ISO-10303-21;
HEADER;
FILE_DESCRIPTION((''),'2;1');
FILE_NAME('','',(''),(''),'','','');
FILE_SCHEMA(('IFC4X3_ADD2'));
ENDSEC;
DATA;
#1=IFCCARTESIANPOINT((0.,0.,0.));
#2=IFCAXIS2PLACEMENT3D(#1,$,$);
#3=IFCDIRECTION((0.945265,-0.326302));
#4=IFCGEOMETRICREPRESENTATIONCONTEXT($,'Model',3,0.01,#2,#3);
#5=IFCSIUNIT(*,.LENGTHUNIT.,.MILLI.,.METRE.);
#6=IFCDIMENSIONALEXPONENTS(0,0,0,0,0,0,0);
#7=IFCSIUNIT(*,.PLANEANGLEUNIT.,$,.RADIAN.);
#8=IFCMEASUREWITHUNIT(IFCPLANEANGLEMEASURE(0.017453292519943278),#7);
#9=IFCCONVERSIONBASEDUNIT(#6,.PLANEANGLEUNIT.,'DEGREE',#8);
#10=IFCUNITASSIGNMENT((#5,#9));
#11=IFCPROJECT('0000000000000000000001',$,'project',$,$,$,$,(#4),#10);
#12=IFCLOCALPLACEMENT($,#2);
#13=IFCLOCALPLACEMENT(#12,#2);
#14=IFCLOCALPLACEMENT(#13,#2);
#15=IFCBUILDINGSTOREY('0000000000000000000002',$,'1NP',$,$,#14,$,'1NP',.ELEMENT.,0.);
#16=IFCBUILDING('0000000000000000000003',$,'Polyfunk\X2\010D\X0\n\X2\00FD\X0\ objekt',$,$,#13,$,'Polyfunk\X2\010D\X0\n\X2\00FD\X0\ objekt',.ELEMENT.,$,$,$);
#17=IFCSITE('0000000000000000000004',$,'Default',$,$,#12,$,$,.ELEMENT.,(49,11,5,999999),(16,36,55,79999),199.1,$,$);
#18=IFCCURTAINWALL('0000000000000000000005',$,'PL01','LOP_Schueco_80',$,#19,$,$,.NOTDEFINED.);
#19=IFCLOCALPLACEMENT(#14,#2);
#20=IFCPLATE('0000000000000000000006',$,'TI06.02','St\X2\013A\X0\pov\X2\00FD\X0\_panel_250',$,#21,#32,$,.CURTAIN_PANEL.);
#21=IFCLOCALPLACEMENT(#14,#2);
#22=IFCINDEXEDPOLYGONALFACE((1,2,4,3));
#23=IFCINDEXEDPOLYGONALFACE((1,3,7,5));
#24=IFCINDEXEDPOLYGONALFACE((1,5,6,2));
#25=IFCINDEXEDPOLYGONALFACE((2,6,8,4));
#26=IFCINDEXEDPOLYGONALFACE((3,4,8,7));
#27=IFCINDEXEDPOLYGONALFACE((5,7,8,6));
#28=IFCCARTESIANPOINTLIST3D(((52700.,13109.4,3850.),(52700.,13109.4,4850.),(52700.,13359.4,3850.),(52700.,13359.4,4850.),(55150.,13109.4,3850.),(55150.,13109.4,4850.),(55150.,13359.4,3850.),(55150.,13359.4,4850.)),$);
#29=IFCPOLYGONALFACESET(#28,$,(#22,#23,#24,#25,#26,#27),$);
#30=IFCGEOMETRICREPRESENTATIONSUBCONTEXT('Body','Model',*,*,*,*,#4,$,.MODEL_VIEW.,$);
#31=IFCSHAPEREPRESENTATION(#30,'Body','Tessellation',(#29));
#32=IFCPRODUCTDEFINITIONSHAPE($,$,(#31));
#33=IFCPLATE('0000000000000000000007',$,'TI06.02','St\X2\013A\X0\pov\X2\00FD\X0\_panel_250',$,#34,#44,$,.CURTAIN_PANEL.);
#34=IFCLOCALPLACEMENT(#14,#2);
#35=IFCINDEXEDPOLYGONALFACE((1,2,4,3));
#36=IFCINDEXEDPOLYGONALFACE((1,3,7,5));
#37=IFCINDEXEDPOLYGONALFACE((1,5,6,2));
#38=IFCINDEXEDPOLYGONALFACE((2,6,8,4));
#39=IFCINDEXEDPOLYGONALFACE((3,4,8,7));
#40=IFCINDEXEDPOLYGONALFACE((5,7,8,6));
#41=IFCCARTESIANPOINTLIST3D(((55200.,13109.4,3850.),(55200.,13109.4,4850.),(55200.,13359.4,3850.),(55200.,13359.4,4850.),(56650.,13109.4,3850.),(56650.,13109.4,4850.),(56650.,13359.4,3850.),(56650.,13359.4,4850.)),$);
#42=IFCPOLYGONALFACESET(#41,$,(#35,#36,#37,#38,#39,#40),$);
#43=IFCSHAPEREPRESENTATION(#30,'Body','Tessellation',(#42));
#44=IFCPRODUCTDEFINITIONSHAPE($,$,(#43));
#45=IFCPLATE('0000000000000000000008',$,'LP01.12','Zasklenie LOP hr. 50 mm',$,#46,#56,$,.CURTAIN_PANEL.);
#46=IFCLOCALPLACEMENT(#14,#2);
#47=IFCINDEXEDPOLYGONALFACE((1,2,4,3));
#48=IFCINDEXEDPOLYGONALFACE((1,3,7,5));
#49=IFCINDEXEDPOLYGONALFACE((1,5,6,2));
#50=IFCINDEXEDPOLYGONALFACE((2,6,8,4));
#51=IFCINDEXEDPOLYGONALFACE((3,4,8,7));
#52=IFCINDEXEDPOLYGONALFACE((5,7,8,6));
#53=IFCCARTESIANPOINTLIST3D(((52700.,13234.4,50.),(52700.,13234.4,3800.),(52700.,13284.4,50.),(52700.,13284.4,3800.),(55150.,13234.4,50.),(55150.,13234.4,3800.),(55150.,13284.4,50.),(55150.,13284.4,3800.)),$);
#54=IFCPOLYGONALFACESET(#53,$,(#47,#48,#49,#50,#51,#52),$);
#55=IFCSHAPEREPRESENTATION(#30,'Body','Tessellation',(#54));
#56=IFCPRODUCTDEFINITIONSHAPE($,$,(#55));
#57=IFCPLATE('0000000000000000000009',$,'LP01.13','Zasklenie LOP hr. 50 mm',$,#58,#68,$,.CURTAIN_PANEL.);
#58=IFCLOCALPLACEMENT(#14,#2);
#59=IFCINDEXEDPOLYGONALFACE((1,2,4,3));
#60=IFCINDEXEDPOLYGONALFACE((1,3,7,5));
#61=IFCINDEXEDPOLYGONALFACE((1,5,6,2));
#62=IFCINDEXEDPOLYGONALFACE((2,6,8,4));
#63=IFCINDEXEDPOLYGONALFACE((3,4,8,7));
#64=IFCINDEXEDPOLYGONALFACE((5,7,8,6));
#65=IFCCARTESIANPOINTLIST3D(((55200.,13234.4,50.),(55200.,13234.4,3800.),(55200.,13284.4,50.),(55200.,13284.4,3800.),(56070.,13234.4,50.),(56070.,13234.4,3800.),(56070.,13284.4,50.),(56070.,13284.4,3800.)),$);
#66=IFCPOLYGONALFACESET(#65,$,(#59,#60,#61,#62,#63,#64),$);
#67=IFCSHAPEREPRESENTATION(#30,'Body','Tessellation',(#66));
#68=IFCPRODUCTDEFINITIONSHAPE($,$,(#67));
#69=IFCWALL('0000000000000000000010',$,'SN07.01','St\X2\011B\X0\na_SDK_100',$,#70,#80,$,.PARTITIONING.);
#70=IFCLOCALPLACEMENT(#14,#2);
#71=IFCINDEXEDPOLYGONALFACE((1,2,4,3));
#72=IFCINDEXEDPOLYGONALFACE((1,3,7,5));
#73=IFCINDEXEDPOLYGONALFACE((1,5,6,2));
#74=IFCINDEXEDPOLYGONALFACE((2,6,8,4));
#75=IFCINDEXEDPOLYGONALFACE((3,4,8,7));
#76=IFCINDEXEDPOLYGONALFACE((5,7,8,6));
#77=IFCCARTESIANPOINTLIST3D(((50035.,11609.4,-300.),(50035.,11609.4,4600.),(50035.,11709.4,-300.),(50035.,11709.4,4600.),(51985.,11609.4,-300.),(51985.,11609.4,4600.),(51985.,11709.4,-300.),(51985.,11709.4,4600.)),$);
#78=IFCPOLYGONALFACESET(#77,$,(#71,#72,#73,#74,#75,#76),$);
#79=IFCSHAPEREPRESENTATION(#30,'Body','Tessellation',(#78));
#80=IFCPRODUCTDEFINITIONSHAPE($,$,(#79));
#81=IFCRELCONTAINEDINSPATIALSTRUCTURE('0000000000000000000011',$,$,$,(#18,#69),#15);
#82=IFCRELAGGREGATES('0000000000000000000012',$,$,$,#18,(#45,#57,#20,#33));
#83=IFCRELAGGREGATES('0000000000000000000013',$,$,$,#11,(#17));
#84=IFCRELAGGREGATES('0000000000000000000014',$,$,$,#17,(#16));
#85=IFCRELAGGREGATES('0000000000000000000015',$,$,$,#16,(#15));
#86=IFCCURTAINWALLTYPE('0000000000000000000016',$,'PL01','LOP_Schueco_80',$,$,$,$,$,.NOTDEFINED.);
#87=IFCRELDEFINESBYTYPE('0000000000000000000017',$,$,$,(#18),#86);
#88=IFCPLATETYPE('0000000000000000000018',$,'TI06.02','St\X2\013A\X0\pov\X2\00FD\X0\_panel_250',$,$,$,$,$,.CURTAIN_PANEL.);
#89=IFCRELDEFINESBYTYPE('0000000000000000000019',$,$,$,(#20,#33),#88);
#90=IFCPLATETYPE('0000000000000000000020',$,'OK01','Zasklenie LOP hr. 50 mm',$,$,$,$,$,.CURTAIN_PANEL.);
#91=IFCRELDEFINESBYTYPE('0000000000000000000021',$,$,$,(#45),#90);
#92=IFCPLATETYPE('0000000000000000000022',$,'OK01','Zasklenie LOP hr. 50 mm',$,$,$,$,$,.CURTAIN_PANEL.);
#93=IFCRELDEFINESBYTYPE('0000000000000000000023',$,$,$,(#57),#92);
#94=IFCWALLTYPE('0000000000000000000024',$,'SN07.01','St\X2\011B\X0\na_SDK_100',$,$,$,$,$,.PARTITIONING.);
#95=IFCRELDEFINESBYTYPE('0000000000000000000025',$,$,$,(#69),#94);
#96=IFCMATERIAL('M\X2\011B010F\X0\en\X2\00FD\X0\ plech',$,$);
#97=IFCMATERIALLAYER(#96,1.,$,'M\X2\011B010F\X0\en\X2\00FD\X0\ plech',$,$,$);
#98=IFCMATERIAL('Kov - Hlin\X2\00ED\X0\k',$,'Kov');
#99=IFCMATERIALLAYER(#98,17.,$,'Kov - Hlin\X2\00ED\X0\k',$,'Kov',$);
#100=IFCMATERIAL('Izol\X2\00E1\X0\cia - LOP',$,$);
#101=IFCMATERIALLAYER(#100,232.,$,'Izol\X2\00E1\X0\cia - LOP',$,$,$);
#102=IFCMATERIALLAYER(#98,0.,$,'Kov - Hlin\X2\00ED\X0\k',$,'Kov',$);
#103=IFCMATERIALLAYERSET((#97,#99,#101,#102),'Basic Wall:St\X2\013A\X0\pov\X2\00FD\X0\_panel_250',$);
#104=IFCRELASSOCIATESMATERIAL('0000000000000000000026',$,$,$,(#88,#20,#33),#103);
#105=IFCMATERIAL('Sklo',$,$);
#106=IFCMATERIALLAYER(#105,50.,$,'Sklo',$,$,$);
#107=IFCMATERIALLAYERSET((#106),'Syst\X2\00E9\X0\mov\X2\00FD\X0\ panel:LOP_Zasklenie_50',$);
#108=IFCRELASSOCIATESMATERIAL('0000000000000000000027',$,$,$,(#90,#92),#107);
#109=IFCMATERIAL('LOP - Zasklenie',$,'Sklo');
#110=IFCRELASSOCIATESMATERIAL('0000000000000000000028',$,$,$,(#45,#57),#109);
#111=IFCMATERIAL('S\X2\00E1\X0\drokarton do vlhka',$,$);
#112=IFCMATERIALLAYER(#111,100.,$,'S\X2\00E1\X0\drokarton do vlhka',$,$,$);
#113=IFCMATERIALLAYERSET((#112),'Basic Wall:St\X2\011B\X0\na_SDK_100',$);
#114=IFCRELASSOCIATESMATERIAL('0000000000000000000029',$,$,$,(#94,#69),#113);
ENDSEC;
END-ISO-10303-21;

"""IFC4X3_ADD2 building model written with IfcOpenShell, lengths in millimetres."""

from ifc_helpers import new_model, entity, si_unit, converted_unit, direction, frame, frame_2d, origin, origin_2d_with_axis, place, context, subcontext, project, spatial, polyline, rectangle, extrude, clip, bounded_halfspace, source, transform, mapped, material, layer, layer_set, layer_usage, type_object, type_shapes, element, aggregate, save


model = new_model("IFC4X3_ADD2")

# Units and contexts
model_context = context("Model", 3, precision=0.01, world=origin(), true_north=direction((0.945265, -0.326302)))
body_context = subcontext(model_context, "Body", "Model", "MODEL_VIEW")
ifc_project = project(units=[si_unit("LENGTHUNIT", "METRE", prefix="MILLI"), converted_unit("PLANEANGLEUNIT", "DEGREE", entity("IfcPlaneAngleMeasure", 0.017453292519943278), si_unit("PLANEANGLEUNIT", "RADIAN"), dimensions=[0, 0, 0, 0, 0, 0, 0])], contexts=[model_context])

# Site, building, storey
site_placement = place(None, origin())
site = spatial("IfcSite", under=ifc_project, at=site_placement, Name="Default", CompositionType="ELEMENT", RefLatitude=(49, 11, 5, 999999), RefLongitude=(16, 36, 55, 79999), RefElevation=199.1)
building_placement = place(site_placement, origin())
building = spatial("IfcBuilding", under=site, at=building_placement, Name="Polyfunkčný objekt", LongName="Polyfunkčný objekt", CompositionType="ELEMENT")
storey_placement = place(building_placement, origin())
storey = spatial("IfcBuildingStorey", under=building, at=storey_placement, Name="1NP", LongName="1NP", CompositionType="ELEMENT", Elevation=0.0)

# Curtain wall, plates
curtain_wall_type = type_object("IfcCurtainWallType", Name="PL01", Description="LOP_Schueco_80", PredefinedType="NOTDEFINED")
curtain_wall_placement = place(storey_placement, origin())
curtain_wall = element("IfcCurtainWall", 1, at=curtain_wall_placement, inside=storey, type_object=curtain_wall_type, Name="PL01", Description="LOP_Schueco_80", PredefinedType="NOTDEFINED")
ifc_material_1 = material(Name="Měďený plech")
ifc_layer_1 = layer(ifc_material_1, 1.0, Name="Měďený plech")
ifc_material_2 = material(Name="Kov - Hliník", Category="Kov")
ifc_layer_2 = layer(ifc_material_2, 17.0, Name="Kov - Hliník", Category="Kov")
ifc_material_3 = material(Name="Izolácia - LOP")
ifc_layer_3 = layer(ifc_material_3, 232.0, Name="Izolácia - LOP")
ifc_layer_4 = layer(ifc_material_2, 0.0, Name="Kov - Hliník", Category="Kov")
ifc_layer_set_1 = layer_set([ifc_layer_1, ifc_layer_2, ifc_layer_3, ifc_layer_4], Name="Basic Wall:Stĺpový_panel_250")
ifc_layer_usage_1 = layer_usage(ifc_layer_set_1, "AXIS2", "NEGATIVE", 125.0)
plate_type_1 = type_object("IfcPlateType", Name="TI06.02", Description="Stĺpový_panel_250", PredefinedType="CURTAIN_PANEL", material=ifc_layer_set_1)
plate_1_placement = place(storey_placement, frame((52700.0, 13234.4, 3850.0)))
plate_1 = element("IfcPlate", 2, at=plate_1_placement, type_object=plate_type_1, material=ifc_layer_usage_1, Name="TI06.02", Description="Stĺpový_panel_250", PredefinedType="CURTAIN_PANEL", context=body_context, shape_type="SweptSolid", body=[
    extrude(rectangle(XDim=250.0, YDim=2450.0, at=origin_2d_with_axis()), frame((1225.0, 0.0, 0.0), z_axis=(0.0, 0.0, 1.0), x_axis=(0.0, 1.0, 0.0)), (0.0, 0.0, 1.0), 1000.0),
])
ifc_layer_usage_2 = layer_usage(ifc_layer_set_1, "AXIS2", "NEGATIVE", 125.0)
plate_2_placement = place(storey_placement, frame((55200.0, 13234.4, 3850.0)))
plate_2 = element("IfcPlate", 3, at=plate_2_placement, type_object=plate_type_1, material=ifc_layer_usage_2, Name="TI06.02", Description="Stĺpový_panel_250", PredefinedType="CURTAIN_PANEL", context=body_context, shape_type="SweptSolid", body=[
    extrude(rectangle(XDim=250.0, YDim=1450.0, at=origin_2d_with_axis()), frame((725.0, 0.0, 0.0), z_axis=(0.0, 0.0, 1.0), x_axis=(0.0, 1.0, 0.0)), (0.0, 0.0, 1.0), 1000.0),
])
ifc_material_4 = material(Name="LOP - Zasklenie", Category="Sklo")
ifc_material_5 = material(Name="Sklo")
ifc_layer_5 = layer(ifc_material_5, 50.0, Name="Sklo")
ifc_layer_set_2 = layer_set([ifc_layer_5], Name="Systémový panel:LOP_Zasklenie_50")
plate_type_2 = type_object("IfcPlateType", Name="OK01", Description="Zasklenie LOP hr. 50 mm", PredefinedType="CURTAIN_PANEL", material=ifc_layer_set_2)
shared_shape_1 = source(origin(), body_context, "Body", "SweptSolid", [
    extrude(rectangle(XDim=3750.0, YDim=2450.0, at=frame_2d((-141.7, 0.0), x_axis=(1.0, 0.0))), frame((0.0, 0.0, 2016.7), z_axis=(0.0, 1.0, 0.0), x_axis=(0.0, 0.0, 1.0)), (0.0, 0.0, 1.0), 50.0),
])
type_shapes(plate_type_2, [shared_shape_1])
plate_3_placement = place(curtain_wall_placement, frame((53925.0, 13234.4, 50.0)))
plate_3 = element("IfcPlate", 4, at=plate_3_placement, type_object=plate_type_2, material=ifc_material_4, Name="LP01.12", Description="Zasklenie LOP hr. 50 mm", PredefinedType="CURTAIN_PANEL", context=body_context, shape_type="MappedRepresentation", body=[
    mapped(shared_shape_1, transform((0.0, 0.0, 0.0), scale=1.0)),
])
plate_type_3 = type_object("IfcPlateType", Name="OK01", Description="Zasklenie LOP hr. 50 mm", PredefinedType="CURTAIN_PANEL", material=ifc_layer_set_2)
shared_shape_2 = source(origin(), body_context, "Body", "SweptSolid", [
    extrude(rectangle(XDim=3750.0, YDim=870.0, at=frame_2d((-141.7, 0.0), x_axis=(1.0, 0.0))), frame((0.0, 0.0, 2016.7), z_axis=(0.0, 1.0, 0.0), x_axis=(0.0, 0.0, 1.0)), (0.0, 0.0, 1.0), 50.0),
])
type_shapes(plate_type_3, [shared_shape_2])
plate_4_placement = place(curtain_wall_placement, frame((55635.0, 13234.4, 50.0)))
plate_4 = element("IfcPlate", 5, at=plate_4_placement, type_object=plate_type_3, material=ifc_material_4, Name="LP01.13", Description="Zasklenie LOP hr. 50 mm", PredefinedType="CURTAIN_PANEL", context=body_context, shape_type="MappedRepresentation", body=[
    mapped(shared_shape_2, transform((0.0, 0.0, 0.0), scale=1.0)),
])
aggregate(curtain_wall, [plate_3, plate_4, plate_1, plate_2])

# Wall
ifc_material_6 = material(Name="Sádrokarton do vlhka")
ifc_layer_6 = layer(ifc_material_6, 100.0, Name="Sádrokarton do vlhka")
ifc_layer_set_3 = layer_set([ifc_layer_6], Name="Basic Wall:Stěna_SDK_100")
wall_type = type_object("IfcWallType", Name="SN07.01", Description="Stěna_SDK_100", PredefinedType="PARTITIONING", material=ifc_layer_set_3)
wall_placement = place(storey_placement, frame((51985.0, 11659.4, -300.0), z_axis=(0.0, 0.0, 1.0), x_axis=(-1.0, 0.0, 0.0)))
element("IfcWall", 6, at=wall_placement, inside=storey, type_object=wall_type, material=ifc_layer_set_3, Name="SN07.01", Description="Stěna_SDK_100", PredefinedType="PARTITIONING", context=body_context, shape_type="Clipping", body=[
    clip(clip(extrude(rectangle(XDim=1950.0, YDim=100.0, at=frame_2d((975.0, 0.0), x_axis=(-1.0, 0.0))), origin(), (0.0, 0.0, 1.0), 4900.0), bounded_halfspace(frame((0.0, -50.0, 4900.0), z_axis=(0.0, 0.0, -1.0), x_axis=(-1.0, 0.0, 0.0)), True, frame((0.0, -50.0, 4900.0)), polyline([(0.0, 0.0), (1950.0, 0.0), (1950.0, 100.0), (1050.0, 100.0), (900.0, 100.0), (0.0, 100.0), (0.0, 0.0)]))), bounded_halfspace(frame((1950.0, -50.0, 0.0), z_axis=(0.0, 0.0, 1.0), x_axis=(0.0, -1.0, 0.0)), True, frame((1950.0, -50.0, 0.0)), polyline([(0.0, 0.0), (0.0, 100.0), (-900.0, 100.0), (-1050.0, 100.0), (-1950.0, 100.0), (-1950.0, 0.0), (0.0, 0.0)]))),
])

save(model, "model.ifc")
